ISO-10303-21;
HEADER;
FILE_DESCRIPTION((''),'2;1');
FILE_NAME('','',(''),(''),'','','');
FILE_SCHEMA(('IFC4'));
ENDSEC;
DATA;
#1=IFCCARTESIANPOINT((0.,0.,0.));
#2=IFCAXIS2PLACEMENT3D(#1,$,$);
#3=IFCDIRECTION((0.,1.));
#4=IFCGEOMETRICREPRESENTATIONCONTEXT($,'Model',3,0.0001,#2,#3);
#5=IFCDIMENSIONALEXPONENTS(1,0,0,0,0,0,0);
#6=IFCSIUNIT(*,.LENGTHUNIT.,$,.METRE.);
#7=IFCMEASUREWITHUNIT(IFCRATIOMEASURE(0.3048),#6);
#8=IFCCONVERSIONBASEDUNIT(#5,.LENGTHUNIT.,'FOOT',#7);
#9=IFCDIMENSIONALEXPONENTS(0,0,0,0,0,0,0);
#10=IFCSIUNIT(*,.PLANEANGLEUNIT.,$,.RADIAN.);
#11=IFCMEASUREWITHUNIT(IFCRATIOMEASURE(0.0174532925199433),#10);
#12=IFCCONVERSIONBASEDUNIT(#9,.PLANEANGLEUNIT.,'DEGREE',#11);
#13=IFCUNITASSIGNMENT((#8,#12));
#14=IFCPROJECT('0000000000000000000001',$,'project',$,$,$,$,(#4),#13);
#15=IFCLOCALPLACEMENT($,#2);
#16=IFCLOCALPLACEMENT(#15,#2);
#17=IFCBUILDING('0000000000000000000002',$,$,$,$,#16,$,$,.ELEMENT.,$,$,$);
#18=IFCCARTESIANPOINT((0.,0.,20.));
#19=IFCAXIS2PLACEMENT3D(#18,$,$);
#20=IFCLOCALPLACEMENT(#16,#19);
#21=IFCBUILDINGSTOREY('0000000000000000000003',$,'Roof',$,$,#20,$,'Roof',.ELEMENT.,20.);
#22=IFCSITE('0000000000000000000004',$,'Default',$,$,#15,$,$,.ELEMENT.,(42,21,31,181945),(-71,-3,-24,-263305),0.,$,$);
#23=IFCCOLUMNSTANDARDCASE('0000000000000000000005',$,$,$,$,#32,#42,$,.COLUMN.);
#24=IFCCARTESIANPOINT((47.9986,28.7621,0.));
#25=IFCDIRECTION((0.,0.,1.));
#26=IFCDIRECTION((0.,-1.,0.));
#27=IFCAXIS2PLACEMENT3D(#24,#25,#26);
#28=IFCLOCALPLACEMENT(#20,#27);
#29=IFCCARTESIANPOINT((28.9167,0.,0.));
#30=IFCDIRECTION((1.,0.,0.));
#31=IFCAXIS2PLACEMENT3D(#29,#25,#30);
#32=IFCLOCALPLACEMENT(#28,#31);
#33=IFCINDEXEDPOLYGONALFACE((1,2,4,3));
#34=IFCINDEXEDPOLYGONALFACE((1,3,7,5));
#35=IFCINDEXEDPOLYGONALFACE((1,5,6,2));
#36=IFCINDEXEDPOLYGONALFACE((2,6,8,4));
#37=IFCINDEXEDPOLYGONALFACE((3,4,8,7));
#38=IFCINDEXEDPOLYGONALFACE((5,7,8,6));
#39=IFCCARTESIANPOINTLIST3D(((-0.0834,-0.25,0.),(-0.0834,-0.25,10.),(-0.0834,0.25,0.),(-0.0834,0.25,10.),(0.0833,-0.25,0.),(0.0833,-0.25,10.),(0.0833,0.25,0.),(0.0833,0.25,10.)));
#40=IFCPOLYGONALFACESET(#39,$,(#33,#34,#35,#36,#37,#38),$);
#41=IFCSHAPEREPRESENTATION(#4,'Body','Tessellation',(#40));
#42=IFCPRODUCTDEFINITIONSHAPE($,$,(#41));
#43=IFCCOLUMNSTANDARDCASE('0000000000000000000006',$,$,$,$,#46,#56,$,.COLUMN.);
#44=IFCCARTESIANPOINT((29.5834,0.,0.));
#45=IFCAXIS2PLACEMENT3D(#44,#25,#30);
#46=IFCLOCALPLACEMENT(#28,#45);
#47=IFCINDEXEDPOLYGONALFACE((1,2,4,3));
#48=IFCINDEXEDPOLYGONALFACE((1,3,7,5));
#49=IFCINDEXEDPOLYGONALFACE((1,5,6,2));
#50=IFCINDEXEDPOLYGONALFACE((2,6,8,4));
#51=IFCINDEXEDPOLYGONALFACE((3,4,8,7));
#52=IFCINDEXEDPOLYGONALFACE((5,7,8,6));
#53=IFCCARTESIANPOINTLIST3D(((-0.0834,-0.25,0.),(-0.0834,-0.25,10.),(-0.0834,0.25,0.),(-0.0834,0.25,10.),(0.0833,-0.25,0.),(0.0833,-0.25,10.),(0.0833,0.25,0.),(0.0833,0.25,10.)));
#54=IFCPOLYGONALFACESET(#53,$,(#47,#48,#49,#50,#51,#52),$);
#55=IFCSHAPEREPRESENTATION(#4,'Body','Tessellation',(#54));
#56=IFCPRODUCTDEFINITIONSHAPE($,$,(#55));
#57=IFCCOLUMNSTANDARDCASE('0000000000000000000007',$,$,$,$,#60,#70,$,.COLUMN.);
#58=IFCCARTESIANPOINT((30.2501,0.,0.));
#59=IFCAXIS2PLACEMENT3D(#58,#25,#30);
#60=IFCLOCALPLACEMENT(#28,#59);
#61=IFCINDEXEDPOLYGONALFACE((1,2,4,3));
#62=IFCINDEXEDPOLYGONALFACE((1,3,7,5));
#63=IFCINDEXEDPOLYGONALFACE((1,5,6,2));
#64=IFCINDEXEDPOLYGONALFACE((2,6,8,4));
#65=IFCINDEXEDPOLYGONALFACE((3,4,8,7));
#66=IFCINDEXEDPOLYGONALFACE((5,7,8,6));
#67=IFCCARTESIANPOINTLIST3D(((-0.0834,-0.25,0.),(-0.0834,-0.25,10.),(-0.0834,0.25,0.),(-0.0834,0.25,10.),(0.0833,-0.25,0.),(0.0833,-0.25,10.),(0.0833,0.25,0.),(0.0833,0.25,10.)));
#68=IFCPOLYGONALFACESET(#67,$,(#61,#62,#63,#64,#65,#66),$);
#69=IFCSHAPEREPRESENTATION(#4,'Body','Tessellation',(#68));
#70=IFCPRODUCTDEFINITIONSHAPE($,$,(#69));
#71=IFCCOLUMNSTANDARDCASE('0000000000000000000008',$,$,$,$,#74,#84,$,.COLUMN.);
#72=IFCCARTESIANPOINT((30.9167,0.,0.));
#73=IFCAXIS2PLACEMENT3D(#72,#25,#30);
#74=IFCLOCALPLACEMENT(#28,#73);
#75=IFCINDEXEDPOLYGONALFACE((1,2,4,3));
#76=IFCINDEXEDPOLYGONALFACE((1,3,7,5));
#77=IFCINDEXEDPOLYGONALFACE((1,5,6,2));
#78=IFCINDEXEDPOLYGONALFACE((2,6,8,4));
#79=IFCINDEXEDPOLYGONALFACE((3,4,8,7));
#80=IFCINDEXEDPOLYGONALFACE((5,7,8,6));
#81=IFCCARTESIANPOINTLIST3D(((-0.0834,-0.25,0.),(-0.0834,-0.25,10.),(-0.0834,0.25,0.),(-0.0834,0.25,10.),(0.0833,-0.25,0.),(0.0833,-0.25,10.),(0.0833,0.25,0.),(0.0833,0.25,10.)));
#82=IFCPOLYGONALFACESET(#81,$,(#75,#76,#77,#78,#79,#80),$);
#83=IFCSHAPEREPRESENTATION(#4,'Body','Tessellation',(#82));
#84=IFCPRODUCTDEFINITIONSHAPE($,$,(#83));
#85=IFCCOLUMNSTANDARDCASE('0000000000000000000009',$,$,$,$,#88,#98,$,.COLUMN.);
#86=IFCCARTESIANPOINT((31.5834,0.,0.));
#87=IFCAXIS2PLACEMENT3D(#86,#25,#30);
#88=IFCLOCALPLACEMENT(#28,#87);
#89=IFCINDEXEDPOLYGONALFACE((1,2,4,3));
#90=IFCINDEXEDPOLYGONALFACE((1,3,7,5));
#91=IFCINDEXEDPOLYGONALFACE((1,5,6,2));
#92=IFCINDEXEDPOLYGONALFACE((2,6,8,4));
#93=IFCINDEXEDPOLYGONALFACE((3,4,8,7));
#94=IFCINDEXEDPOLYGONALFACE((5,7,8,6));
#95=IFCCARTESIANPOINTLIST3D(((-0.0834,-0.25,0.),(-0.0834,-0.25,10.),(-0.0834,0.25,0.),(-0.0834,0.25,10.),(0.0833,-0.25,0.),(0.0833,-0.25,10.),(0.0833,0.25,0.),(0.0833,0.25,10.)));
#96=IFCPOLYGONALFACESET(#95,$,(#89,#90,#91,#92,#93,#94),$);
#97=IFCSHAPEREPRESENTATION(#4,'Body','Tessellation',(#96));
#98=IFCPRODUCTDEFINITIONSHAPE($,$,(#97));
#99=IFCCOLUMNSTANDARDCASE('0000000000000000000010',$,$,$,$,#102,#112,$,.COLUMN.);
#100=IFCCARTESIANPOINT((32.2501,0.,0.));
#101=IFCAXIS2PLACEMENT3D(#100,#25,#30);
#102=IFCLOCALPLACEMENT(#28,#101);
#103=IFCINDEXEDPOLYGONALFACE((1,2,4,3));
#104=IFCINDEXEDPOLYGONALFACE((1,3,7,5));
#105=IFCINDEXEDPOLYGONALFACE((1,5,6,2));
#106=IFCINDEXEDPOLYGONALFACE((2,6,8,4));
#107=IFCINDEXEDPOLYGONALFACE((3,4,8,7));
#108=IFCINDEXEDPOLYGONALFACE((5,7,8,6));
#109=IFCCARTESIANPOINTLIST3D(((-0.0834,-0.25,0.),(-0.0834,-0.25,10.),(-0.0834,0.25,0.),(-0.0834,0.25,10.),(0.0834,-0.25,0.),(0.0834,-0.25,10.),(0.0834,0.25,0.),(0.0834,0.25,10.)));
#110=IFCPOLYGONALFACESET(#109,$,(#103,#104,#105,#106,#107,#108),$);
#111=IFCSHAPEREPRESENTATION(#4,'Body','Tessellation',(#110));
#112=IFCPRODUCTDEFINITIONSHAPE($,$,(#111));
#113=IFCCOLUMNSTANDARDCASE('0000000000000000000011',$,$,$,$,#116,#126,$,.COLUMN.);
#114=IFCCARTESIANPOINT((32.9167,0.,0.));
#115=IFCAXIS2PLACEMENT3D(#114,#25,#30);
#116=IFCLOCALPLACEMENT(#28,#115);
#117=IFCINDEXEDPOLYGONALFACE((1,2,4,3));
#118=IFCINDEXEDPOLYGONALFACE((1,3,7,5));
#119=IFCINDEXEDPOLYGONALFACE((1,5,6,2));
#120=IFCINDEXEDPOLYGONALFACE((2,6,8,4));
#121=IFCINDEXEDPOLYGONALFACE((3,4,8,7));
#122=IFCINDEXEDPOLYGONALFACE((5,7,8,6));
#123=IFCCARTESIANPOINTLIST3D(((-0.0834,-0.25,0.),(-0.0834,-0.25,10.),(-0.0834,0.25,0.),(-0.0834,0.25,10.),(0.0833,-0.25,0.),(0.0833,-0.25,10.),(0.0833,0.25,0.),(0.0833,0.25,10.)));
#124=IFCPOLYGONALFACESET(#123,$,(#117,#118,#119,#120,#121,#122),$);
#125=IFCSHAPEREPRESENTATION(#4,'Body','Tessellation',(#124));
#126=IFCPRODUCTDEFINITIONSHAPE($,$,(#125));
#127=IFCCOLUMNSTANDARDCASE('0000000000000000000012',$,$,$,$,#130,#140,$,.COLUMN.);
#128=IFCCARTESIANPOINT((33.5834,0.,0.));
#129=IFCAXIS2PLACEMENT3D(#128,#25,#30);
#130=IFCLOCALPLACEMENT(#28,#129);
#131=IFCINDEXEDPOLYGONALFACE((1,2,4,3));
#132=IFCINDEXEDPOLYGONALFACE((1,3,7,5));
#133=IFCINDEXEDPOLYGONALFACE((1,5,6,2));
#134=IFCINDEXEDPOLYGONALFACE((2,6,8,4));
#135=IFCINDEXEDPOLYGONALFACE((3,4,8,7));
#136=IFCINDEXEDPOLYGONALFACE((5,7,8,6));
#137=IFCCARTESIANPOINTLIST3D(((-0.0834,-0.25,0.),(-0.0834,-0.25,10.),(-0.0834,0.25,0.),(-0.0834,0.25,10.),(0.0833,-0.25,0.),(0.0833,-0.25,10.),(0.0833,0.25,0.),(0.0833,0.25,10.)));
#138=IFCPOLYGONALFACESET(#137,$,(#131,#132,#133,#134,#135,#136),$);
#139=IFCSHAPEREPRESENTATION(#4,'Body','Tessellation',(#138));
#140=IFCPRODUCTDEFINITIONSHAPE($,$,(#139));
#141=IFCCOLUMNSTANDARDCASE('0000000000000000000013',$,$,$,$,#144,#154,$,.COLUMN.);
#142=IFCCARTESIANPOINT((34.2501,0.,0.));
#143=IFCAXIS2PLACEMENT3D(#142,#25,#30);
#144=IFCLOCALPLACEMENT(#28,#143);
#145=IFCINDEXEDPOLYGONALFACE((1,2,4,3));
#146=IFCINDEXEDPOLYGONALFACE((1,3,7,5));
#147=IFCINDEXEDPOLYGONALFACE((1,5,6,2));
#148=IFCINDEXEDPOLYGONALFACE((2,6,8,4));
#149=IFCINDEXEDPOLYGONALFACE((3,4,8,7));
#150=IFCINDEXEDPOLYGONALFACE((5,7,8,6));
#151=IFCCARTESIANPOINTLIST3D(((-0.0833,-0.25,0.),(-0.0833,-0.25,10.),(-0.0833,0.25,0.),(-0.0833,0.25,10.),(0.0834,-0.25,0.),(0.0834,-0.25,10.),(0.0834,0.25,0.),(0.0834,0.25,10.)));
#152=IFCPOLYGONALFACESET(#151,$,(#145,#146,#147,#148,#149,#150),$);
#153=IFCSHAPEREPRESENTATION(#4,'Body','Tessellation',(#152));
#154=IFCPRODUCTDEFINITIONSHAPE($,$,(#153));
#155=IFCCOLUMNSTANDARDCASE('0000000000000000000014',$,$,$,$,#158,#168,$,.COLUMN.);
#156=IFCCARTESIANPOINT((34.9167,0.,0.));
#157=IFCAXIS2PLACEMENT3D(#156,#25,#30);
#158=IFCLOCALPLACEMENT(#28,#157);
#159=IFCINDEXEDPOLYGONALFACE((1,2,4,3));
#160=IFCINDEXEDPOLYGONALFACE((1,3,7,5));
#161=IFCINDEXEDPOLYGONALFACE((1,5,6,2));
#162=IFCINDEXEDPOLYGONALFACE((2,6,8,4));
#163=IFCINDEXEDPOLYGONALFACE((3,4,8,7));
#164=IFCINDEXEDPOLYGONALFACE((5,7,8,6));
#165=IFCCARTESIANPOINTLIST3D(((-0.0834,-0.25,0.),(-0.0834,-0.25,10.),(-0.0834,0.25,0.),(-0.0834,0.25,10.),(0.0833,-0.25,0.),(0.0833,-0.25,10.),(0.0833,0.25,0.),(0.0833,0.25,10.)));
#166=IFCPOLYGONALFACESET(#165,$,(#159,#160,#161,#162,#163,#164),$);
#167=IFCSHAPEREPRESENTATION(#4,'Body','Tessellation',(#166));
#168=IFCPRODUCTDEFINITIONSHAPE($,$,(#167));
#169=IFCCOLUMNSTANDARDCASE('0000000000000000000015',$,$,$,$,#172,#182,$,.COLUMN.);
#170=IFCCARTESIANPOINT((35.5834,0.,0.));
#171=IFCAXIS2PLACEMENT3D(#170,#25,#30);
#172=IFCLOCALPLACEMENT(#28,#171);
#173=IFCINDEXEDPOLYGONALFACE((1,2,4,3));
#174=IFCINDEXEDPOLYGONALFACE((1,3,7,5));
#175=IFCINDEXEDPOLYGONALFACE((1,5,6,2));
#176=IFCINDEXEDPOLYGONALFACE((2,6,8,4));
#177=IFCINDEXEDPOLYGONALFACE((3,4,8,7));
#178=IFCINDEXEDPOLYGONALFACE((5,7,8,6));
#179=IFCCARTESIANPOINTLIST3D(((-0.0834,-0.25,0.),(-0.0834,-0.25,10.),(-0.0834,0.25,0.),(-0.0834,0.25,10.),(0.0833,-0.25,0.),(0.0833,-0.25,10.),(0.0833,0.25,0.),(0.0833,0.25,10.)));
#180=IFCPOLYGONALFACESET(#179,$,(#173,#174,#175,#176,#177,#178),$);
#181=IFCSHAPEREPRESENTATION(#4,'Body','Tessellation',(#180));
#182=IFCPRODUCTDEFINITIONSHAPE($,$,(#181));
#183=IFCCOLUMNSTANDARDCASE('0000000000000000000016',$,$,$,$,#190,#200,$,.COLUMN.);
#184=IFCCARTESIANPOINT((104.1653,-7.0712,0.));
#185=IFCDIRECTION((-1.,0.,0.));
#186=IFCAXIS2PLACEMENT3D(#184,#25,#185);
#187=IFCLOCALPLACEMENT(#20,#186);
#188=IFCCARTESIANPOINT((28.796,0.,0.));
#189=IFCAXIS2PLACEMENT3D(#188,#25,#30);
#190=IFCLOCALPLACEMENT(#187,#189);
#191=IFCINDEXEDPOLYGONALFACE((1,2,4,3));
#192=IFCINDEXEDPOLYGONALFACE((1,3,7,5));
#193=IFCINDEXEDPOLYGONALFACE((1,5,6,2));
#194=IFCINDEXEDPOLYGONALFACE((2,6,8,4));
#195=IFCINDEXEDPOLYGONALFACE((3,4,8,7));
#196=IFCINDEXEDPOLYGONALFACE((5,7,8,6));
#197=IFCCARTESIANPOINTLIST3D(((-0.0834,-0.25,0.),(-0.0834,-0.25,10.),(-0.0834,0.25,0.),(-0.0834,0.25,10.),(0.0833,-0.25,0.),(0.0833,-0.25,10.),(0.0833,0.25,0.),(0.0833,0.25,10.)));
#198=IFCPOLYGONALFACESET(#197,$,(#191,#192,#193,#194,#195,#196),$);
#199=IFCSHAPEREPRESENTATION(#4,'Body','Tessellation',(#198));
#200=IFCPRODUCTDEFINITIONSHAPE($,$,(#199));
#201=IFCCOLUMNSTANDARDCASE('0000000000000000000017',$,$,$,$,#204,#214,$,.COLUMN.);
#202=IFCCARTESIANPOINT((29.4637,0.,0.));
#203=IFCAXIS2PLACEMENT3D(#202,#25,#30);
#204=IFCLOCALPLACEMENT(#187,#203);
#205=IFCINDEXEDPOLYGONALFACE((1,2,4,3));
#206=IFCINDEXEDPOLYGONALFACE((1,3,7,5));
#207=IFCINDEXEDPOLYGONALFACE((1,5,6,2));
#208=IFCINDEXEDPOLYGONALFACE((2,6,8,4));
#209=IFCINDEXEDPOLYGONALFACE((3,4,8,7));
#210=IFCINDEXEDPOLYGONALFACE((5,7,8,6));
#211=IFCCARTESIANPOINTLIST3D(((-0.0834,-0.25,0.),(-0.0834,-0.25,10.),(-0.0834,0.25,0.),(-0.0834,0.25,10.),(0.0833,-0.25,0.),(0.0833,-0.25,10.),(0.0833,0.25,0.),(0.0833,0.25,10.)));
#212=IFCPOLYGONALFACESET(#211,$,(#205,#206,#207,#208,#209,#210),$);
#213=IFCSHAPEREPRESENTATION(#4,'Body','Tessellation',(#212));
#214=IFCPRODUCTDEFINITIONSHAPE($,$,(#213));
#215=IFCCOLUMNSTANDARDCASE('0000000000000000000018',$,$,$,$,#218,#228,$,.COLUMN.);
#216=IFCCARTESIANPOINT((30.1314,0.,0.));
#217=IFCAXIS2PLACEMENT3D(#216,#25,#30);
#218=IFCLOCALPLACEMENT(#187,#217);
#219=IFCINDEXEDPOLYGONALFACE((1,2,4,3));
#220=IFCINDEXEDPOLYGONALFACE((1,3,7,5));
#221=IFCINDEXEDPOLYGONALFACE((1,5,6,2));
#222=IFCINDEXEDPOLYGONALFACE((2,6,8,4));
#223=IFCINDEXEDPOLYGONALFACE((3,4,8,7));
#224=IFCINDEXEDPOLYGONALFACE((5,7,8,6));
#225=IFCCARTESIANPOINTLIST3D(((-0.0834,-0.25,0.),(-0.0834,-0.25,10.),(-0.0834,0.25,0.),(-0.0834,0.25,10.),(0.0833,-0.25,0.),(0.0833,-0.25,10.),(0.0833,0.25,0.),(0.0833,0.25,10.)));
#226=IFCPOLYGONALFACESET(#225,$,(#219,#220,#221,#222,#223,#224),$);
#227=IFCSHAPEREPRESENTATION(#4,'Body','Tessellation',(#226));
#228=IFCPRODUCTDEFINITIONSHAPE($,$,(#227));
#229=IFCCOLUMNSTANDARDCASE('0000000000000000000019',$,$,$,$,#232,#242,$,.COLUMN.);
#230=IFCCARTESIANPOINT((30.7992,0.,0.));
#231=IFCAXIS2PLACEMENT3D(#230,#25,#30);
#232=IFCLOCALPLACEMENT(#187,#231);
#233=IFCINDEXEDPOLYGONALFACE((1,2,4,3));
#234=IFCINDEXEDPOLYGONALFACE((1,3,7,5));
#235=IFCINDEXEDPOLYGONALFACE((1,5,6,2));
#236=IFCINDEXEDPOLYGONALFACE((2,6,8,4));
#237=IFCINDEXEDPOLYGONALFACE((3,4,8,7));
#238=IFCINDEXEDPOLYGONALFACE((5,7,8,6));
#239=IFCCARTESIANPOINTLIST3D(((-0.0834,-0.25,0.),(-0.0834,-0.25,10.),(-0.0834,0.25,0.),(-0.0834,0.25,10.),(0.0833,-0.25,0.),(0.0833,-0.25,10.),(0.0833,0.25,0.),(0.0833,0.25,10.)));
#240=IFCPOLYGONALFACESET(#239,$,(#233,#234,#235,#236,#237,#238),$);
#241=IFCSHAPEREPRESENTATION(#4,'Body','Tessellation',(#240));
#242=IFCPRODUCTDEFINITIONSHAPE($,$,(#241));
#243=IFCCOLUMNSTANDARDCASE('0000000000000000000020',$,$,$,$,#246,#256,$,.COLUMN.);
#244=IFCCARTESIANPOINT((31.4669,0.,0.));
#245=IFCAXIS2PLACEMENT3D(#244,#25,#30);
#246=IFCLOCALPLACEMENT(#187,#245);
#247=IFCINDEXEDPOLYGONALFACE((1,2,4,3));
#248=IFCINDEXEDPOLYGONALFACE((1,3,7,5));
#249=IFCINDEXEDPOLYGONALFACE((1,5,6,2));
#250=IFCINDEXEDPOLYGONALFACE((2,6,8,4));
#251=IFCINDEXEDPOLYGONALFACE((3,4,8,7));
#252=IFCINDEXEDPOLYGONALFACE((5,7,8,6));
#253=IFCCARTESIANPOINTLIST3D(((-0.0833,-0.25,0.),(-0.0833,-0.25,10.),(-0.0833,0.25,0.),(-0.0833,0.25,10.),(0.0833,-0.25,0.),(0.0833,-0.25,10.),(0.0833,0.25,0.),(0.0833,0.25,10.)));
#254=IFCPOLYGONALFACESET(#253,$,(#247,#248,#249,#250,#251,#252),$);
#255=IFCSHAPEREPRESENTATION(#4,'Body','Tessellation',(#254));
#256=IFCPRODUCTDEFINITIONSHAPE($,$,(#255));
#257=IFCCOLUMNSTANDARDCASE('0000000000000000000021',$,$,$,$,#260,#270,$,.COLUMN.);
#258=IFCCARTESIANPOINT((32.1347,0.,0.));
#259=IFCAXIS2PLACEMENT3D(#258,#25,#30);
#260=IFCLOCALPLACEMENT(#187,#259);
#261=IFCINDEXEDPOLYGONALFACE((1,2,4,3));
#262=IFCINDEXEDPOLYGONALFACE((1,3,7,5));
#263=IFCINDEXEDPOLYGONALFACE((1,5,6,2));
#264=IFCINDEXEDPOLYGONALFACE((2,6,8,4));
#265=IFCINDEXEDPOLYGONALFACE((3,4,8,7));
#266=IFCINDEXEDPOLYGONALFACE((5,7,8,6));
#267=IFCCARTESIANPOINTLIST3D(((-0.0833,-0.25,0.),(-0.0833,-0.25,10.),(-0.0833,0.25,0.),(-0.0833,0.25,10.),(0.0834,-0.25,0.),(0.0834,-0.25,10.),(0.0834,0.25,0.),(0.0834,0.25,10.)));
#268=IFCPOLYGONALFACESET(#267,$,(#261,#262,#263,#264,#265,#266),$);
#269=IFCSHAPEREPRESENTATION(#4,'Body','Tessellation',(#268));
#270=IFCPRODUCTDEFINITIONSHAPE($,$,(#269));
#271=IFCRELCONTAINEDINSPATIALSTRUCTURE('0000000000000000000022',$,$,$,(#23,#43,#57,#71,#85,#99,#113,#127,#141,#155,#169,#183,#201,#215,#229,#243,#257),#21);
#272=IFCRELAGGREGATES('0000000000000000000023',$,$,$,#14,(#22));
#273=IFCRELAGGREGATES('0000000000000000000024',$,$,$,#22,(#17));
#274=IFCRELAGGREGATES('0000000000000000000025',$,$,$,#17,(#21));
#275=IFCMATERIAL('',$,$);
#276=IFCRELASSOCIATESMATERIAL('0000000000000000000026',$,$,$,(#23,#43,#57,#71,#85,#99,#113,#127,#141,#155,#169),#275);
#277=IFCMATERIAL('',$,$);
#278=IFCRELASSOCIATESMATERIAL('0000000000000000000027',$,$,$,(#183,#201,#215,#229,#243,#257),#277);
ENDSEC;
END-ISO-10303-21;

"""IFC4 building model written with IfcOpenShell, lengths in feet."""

from ifc_helpers import new_model, entity, si_unit, converted_unit, direction, frame, origin, place, context, project, spatial, rectangle, extrude, material, element, save


model = new_model("IFC4")

# Units and contexts
model_context = context("Model", 3, precision=0.0001, world=origin(), true_north=direction((0.0, 1.0)))
ifc_project = project(units=[converted_unit("LENGTHUNIT", "FOOT", entity("IfcRatioMeasure", 0.3048), si_unit("LENGTHUNIT", "METRE"), dimensions=[1, 0, 0, 0, 0, 0, 0]), converted_unit("PLANEANGLEUNIT", "DEGREE", entity("IfcRatioMeasure", 0.0174532925199433), si_unit("PLANEANGLEUNIT", "RADIAN"), dimensions=[0, 0, 0, 0, 0, 0, 0])], contexts=[model_context])

# Site, building, storey
site_placement = place(None, origin())
site = spatial("IfcSite", under=ifc_project, at=site_placement, Name="Default", CompositionType="ELEMENT", RefLatitude=(42, 21, 31, 181945), RefLongitude=(-71, -3, -24, -263305), RefElevation=0.0)
building_placement = place(site_placement, origin())
building = spatial("IfcBuilding", under=site, at=building_placement, CompositionType="ELEMENT")
storey_placement = place(building_placement, frame((0.0, 0.0, 20.0)))
storey = spatial("IfcBuildingStorey", under=building, at=storey_placement, Name="Roof", LongName="Roof", CompositionType="ELEMENT", Elevation=20.0)

# Columns
ifc_material_1 = material(Name="")
placement_1 = place(storey_placement, frame((47.9986, 28.7621, 0.0), z_axis=(0.0, 0.0, 1.0), x_axis=(0.0, -1.0, 0.0)))
for number, where, z_axis, x_axis in (
    (1, (28.9167, 0.0, 0.0), (0.0, 0.0, 1.0), (1.0, 0.0, 0.0)),
    (2, (29.5834, 0.0, 0.0), (0.0, 0.0, 1.0), (1.0, 0.0, 0.0)),
    (3, (30.2501, 0.0, 0.0), (0.0, 0.0, 1.0), (1.0, 0.0, 0.0)),
    (4, (30.9167, 0.0, 0.0), (0.0, 0.0, 1.0), (1.0, 0.0, 0.0)),
    (5, (31.5834, 0.0, 0.0), (0.0, 0.0, 1.0), (1.0, 0.0, 0.0)),
    (6, (32.2501, 0.0, 0.0), (0.0, 0.0, 1.0), (1.0, 0.0, 0.0)),
    (7, (32.9167, 0.0, 0.0), (0.0, 0.0, 1.0), (1.0, 0.0, 0.0)),
    (8, (33.5834, 0.0, 0.0), (0.0, 0.0, 1.0), (1.0, 0.0, 0.0)),
    (9, (34.2501, 0.0, 0.0), (0.0, 0.0, 1.0), (1.0, 0.0, 0.0)),
    (10, (34.9167, 0.0, 0.0), (0.0, 0.0, 1.0), (1.0, 0.0, 0.0)),
    (11, (35.5834, 0.0, 0.0), (0.0, 0.0, 1.0), (1.0, 0.0, 0.0)),
):
    element("IfcColumnStandardCase", number, at=place(placement_1, frame(where, z_axis=z_axis, x_axis=x_axis)), inside=storey, material=ifc_material_1, PredefinedType="COLUMN", context=model_context, shape_type="SweptSolid", body=[
        extrude(rectangle(XDim=0.1667, YDim=0.5), origin(), (0.0, 0.0, 1.0), 10.0),
    ])
ifc_material_2 = material(Name="")
placement_2 = place(storey_placement, frame((104.1653, -7.0712, 0.0), z_axis=(0.0, 0.0, 1.0), x_axis=(-1.0, 0.0, 0.0)))
for number, where, z_axis, x_axis in (
    (12, (28.796, 0.0, 0.0), (0.0, 0.0, 1.0), (1.0, 0.0, 0.0)),
    (13, (29.4637, 0.0, 0.0), (0.0, 0.0, 1.0), (1.0, 0.0, 0.0)),
    (14, (30.1314, 0.0, 0.0), (0.0, 0.0, 1.0), (1.0, 0.0, 0.0)),
    (15, (30.7992, 0.0, 0.0), (0.0, 0.0, 1.0), (1.0, 0.0, 0.0)),
    (16, (31.4669, 0.0, 0.0), (0.0, 0.0, 1.0), (1.0, 0.0, 0.0)),
    (17, (32.1347, 0.0, 0.0), (0.0, 0.0, 1.0), (1.0, 0.0, 0.0)),
):
    element("IfcColumnStandardCase", number, at=place(placement_2, frame(where, z_axis=z_axis, x_axis=x_axis)), inside=storey, material=ifc_material_2, PredefinedType="COLUMN", context=model_context, shape_type="SweptSolid", body=[
        extrude(rectangle(XDim=0.1667, YDim=0.5), origin(), (0.0, 0.0, 1.0), 10.0),
    ])

save(model, "model.ifc")
